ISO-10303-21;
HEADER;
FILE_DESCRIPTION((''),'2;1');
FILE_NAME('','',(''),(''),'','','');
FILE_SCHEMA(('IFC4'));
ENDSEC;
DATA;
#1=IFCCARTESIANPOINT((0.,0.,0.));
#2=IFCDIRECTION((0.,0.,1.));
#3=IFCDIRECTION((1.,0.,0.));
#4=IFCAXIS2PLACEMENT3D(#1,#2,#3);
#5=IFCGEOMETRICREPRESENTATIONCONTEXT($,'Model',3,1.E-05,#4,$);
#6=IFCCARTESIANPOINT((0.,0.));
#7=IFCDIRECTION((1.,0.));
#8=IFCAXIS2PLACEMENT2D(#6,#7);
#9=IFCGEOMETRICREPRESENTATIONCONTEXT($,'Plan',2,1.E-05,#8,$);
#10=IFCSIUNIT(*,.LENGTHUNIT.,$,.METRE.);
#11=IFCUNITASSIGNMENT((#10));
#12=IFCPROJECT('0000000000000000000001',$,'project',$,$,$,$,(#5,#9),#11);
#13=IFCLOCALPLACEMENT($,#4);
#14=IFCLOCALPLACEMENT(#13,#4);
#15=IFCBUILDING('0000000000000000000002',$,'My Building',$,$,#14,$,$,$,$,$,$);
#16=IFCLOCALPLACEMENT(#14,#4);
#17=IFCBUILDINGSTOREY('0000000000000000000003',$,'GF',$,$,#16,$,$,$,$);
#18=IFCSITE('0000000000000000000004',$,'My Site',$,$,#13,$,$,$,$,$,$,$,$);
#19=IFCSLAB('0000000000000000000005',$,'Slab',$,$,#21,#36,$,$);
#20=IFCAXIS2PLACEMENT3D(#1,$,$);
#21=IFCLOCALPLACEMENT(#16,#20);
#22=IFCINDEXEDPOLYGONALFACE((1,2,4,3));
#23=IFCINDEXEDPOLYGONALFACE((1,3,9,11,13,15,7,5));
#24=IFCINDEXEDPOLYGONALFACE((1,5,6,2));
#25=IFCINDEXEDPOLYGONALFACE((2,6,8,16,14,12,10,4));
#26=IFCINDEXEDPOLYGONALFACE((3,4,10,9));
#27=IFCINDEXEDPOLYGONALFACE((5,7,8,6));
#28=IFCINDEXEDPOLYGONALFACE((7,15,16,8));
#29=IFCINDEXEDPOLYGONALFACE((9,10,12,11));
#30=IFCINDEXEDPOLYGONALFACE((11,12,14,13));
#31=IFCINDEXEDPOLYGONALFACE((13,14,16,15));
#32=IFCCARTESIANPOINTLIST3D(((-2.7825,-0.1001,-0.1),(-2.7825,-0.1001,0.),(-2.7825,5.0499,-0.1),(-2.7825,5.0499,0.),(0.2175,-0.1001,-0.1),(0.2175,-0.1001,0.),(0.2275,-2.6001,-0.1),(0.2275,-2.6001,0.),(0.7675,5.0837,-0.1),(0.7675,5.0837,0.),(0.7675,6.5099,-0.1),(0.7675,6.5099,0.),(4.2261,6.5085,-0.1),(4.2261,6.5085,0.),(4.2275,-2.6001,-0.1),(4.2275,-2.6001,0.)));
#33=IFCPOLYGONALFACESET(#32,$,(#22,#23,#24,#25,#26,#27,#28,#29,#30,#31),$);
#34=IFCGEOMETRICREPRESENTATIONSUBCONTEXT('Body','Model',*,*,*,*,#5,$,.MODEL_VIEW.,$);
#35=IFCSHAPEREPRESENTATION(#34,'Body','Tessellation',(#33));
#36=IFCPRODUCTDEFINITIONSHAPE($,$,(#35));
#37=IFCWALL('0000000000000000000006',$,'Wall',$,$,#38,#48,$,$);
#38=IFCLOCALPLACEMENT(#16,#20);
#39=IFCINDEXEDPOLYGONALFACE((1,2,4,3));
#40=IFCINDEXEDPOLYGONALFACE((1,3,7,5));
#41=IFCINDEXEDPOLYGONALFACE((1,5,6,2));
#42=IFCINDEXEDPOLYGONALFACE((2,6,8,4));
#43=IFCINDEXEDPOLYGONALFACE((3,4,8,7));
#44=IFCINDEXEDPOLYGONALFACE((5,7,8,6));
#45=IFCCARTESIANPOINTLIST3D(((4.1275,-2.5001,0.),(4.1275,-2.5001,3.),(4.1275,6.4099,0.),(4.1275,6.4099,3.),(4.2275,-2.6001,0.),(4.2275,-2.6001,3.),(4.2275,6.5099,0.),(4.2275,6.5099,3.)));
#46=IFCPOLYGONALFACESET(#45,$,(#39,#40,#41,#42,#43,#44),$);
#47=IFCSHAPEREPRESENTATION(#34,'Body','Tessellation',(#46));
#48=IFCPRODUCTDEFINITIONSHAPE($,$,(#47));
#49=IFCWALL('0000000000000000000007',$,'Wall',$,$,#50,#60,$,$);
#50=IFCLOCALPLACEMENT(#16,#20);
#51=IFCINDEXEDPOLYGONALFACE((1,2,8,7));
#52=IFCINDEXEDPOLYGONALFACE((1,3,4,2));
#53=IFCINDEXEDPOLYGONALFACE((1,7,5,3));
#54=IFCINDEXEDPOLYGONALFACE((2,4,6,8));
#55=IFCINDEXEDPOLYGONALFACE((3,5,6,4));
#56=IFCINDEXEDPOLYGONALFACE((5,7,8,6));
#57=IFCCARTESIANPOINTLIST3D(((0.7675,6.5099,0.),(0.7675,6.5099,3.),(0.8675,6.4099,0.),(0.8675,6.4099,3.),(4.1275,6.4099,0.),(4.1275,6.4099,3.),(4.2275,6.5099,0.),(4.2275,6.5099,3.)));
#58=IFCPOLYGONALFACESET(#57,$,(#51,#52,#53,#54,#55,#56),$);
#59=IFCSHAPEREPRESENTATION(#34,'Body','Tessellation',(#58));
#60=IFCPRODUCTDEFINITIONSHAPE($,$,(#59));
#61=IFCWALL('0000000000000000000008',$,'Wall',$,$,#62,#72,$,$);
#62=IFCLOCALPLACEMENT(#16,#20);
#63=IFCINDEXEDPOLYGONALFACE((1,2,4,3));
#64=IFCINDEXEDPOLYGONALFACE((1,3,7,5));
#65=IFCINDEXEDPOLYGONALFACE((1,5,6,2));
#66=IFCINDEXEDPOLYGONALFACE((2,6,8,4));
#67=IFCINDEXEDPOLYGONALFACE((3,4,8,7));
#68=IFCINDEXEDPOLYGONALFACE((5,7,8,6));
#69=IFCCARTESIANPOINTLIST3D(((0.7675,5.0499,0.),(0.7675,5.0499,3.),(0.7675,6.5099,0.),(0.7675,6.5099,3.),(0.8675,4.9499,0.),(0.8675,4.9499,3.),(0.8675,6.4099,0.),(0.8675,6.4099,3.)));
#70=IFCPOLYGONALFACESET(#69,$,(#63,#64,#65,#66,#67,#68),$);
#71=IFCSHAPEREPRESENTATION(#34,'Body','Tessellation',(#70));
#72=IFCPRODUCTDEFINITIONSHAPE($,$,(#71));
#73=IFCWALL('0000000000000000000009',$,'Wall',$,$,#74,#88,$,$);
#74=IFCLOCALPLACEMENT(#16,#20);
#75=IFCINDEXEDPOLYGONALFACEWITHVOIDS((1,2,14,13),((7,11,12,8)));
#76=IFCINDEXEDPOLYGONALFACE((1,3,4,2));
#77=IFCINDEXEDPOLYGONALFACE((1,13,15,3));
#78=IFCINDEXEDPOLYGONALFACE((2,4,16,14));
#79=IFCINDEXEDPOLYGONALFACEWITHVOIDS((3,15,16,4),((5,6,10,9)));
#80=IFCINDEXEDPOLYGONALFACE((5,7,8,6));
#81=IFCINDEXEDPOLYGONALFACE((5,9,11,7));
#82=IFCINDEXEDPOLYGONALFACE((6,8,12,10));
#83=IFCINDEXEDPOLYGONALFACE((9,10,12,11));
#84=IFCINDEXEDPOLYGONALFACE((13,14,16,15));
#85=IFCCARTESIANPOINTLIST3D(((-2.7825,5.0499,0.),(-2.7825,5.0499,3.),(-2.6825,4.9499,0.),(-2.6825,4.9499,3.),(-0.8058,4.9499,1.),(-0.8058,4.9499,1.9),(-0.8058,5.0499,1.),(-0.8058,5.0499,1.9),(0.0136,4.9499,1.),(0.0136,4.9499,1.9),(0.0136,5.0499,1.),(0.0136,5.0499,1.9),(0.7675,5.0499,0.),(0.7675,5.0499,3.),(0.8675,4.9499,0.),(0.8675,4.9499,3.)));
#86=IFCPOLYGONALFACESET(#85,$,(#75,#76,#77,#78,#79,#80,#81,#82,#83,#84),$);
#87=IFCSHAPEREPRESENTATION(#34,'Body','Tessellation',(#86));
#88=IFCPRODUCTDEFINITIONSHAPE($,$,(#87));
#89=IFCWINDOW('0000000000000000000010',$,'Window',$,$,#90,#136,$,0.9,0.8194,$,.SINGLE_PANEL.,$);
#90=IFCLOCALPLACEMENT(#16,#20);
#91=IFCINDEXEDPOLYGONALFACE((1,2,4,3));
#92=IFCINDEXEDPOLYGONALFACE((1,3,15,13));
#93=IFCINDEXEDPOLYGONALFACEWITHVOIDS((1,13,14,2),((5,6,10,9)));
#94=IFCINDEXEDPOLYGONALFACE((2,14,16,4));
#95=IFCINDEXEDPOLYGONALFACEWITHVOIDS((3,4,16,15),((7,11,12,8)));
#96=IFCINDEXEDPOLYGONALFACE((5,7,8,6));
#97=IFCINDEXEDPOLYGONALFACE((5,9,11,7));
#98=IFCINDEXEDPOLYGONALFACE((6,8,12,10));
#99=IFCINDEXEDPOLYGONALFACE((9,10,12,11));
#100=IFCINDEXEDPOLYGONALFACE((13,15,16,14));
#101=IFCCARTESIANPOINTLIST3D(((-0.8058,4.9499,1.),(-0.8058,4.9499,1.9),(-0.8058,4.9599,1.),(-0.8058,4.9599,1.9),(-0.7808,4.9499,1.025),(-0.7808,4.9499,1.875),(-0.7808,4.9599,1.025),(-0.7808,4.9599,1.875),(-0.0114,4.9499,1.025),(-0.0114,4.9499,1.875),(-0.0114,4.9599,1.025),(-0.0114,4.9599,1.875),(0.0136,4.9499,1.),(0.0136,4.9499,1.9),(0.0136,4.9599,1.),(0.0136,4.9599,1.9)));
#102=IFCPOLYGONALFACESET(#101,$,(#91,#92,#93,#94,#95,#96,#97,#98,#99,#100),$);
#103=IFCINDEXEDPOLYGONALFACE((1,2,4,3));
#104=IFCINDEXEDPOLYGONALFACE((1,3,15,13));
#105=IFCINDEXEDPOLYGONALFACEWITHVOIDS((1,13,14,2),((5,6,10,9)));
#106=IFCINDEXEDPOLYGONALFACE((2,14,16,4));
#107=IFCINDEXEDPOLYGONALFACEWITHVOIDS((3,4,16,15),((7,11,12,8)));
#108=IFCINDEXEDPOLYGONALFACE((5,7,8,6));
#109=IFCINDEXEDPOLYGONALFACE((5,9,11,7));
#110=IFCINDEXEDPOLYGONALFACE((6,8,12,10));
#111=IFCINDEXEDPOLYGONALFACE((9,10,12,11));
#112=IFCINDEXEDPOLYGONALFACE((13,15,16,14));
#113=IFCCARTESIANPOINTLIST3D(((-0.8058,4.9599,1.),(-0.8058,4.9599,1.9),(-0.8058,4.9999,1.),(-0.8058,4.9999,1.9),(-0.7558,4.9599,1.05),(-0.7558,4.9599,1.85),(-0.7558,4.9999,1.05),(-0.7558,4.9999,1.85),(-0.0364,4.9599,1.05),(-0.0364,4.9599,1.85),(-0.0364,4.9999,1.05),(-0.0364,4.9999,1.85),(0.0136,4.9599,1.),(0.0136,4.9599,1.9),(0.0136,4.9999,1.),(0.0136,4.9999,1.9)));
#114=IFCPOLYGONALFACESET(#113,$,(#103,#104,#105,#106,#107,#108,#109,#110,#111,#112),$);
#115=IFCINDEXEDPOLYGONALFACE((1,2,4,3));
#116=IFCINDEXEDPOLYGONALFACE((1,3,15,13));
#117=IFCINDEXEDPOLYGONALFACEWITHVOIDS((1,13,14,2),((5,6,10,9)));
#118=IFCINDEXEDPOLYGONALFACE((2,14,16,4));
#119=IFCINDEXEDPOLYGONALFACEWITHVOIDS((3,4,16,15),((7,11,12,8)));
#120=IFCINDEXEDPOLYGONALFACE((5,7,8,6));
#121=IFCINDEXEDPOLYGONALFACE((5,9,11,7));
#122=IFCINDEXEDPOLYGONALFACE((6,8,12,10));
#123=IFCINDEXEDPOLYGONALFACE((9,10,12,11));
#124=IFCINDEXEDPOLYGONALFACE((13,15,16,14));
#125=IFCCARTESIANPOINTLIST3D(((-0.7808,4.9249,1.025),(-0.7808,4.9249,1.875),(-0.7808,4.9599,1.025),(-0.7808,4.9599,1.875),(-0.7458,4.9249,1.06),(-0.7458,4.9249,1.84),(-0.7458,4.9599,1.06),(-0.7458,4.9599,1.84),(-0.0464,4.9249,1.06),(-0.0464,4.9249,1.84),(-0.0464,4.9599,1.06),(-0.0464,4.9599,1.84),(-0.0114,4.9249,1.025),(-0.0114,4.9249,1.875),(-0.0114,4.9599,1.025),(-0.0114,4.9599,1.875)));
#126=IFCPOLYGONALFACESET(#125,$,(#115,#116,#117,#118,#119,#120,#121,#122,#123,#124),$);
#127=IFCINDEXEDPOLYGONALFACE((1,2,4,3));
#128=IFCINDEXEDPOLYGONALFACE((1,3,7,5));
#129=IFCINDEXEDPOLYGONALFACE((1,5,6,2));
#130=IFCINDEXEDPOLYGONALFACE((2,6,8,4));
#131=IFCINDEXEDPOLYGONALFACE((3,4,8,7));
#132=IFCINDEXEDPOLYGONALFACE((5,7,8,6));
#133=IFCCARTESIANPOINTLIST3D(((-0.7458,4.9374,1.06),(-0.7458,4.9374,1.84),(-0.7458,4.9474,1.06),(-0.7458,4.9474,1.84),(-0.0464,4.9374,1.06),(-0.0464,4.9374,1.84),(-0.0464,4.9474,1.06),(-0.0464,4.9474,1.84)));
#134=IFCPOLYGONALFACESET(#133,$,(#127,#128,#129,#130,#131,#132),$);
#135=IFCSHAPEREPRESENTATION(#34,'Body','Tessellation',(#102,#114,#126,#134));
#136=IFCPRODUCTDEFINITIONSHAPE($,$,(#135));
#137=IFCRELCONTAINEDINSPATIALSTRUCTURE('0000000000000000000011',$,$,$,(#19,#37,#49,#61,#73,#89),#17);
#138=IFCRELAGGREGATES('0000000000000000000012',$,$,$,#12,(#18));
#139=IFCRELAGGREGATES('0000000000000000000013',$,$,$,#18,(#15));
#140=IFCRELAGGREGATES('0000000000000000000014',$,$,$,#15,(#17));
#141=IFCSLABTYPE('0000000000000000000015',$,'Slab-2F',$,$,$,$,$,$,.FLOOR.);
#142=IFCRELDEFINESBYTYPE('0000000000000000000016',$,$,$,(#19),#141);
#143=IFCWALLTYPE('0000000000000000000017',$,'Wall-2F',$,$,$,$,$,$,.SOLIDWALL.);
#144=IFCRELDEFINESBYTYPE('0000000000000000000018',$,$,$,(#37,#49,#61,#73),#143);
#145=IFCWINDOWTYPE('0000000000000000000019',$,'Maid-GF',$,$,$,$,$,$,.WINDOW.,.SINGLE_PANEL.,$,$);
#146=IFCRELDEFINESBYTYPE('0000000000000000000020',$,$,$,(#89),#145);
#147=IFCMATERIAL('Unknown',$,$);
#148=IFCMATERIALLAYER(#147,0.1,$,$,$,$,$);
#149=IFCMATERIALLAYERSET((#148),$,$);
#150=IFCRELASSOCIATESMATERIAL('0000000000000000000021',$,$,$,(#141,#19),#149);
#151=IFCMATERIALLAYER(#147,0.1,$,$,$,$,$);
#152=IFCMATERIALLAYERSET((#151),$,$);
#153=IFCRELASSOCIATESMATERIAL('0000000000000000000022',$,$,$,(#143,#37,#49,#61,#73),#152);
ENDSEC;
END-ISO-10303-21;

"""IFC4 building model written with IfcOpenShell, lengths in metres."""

from ifc_helpers import new_model, entity, si_unit, frame, origin_with_axes, origin_2d_with_axis, place, context, subcontext, project, spatial, line, indexed_curve, outline, extrude, shape, source, transform, mapped, material, layer, layer_set, layer_usage, type_object, type_shapes, element, fill, save


model = new_model("IFC4")

# Units and contexts
model_context = context("Model", 3, precision=1e-05, world=origin_with_axes())
plan_context = context("Plan", 2, precision=1e-05, world=origin_2d_with_axis())
body_context_1 = subcontext(model_context, "Body", "Model", "MODEL_VIEW")
body_context_2 = subcontext(plan_context, "Body", "Plan", "PLAN_VIEW")
ifc_project = project(units=[si_unit("LENGTHUNIT", "METRE")], contexts=[model_context, plan_context])

# Site, building, storey
site_placement = place(None, origin_with_axes())
site = spatial("IfcSite", under=ifc_project, at=site_placement, Name="My Site")
building_placement = place(site_placement, origin_with_axes())
building = spatial("IfcBuilding", under=site, at=building_placement, Name="My Building")
storey_placement = place(building_placement, origin_with_axes())
storey = spatial("IfcBuildingStorey", under=building, at=storey_placement, Name="GF")

# Slab
ifc_material = material(Name="Unknown")
ifc_layer_1 = layer(ifc_material, 0.1)
ifc_layer_set_1 = layer_set([ifc_layer_1])
ifc_layer_usage_1 = layer_usage(ifc_layer_set_1, "AXIS3", "POSITIVE", -0.1)
slab_type = type_object("IfcSlabType", Name="Slab-2F", PredefinedType="FLOOR", material=ifc_layer_set_1)
slab_placement = place(storey_placement, frame((4.2275, -2.6001, 0.0), z_axis=(0.0, 0.0, 1.0), x_axis=(1.0, 0.0, 0.0)))
element("IfcSlab", 1, at=slab_placement, inside=storey, type_object=slab_type, material=ifc_layer_usage_1, Name="Slab", context=body_context_1, shape_type="SweptSolid", body=[
    extrude(outline(indexed_curve([(0.0, 0.0), (-0.0014, 9.1086), (-3.46, 9.11), (-3.46, 7.6838), (-7.01, 7.65), (-7.01, 2.5), (-4.01, 2.5), (-4.0, 0.0), (0.0, 0.0)])), frame((0.0, 0.0, -0.1), z_axis=(0.0, 0.0, 1.0), x_axis=(1.0, 0.0, 0.0)), (0.0, 0.0, 1.0), 0.1),
])

# Shared definitions
ifc_layer_2 = layer(ifc_material, 0.1)
ifc_layer_set_2 = layer_set([ifc_layer_2])
wall_type = type_object("IfcWallType", Name="Wall-2F", PredefinedType="SOLIDWALL", material=ifc_layer_set_2)

# Walls
ifc_layer_usage_2 = layer_usage(ifc_layer_set_2, "AXIS2", "POSITIVE", 0.0)
wall_1_placement = place(storey_placement, frame((4.2275, -2.6001, 0.0), z_axis=(0.0, 0.0, 1.0), x_axis=(0.0, 1.0, 0.0)))
element("IfcWall", 2, at=wall_1_placement, inside=storey, type_object=wall_type, material=ifc_layer_usage_2, Name="Wall", context=body_context_1, shape_type="SweptSolid", body=[
    extrude(outline(indexed_curve([(0.0, 0.0), (0.1, 0.1), (9.01, 0.1), (9.11, 0.0)], segments=[line(1, 2, 3, 4, 1)])), origin_with_axes(), (0.0, 0.0, 1.0), 3.0),
])
ifc_layer_usage_3 = layer_usage(ifc_layer_set_2, "AXIS2", "POSITIVE", 0.0)
wall_2_placement = place(storey_placement, frame((4.2275, 6.5099, 0.0), z_axis=(0.0, 0.0, 1.0), x_axis=(-1.0, 0.0, 0.0)))
element("IfcWall", 3, at=wall_2_placement, inside=storey, type_object=wall_type, material=ifc_layer_usage_3, Name="Wall", context=body_context_1, shape_type="SweptSolid", body=[
    extrude(outline(indexed_curve([(0.0, 0.0), (0.1, 0.1), (3.36, 0.1), (3.46, 0.0)], segments=[line(1, 2, 3, 4, 1)])), origin_with_axes(), (0.0, 0.0, 1.0), 3.0),
])
ifc_layer_usage_4 = layer_usage(ifc_layer_set_2, "AXIS2", "POSITIVE", 0.0)
wall_3_placement = place(storey_placement, frame((0.7675, 6.5099, 0.0), z_axis=(0.0, 0.0, 1.0), x_axis=(0.0, -1.0, 0.0)))
element("IfcWall", 4, at=wall_3_placement, inside=storey, type_object=wall_type, material=ifc_layer_usage_4, Name="Wall", context=body_context_1, shape_type="SweptSolid", body=[
    extrude(outline(indexed_curve([(0.0, 0.0), (0.1, 0.1), (1.56, 0.1), (1.46, 0.0)], segments=[line(1, 2, 3, 4, 1)])), origin_with_axes(), (0.0, 0.0, 1.0), 3.0),
])

# Wall, opening, window
ifc_layer_usage_5 = layer_usage(ifc_layer_set_2, "AXIS2", "POSITIVE", 0.0)
wall_4_placement = place(storey_placement, frame((0.7675, 5.0499, 0.0), z_axis=(0.0, 0.0, 1.0), x_axis=(-1.0, 0.0, 0.0)))
wall_4 = element("IfcWall", 5, at=wall_4_placement, inside=storey, type_object=wall_type, material=ifc_layer_usage_5, Name="Wall", context=body_context_1, shape_type="SweptSolid", body=[
    extrude(outline(indexed_curve([(0.0, 0.0), (-0.1, 0.1), (3.45, 0.1), (3.55, 0.0)], segments=[line(1, 2, 3, 4, 1)])), origin_with_axes(), (0.0, 0.0, 1.0), 3.0),
])
shared_shape_1 = source(origin_with_axes(), body_context_1, "Body", "SweptSolid", [
    extrude(outline(indexed_curve([(0.0, 0.0), (0.8194, 0.0), (0.8194, 0.9), (0.0, 0.9)], segments=[line(1, 2, 3, 4, 1)])), frame((0.0, -0.6, 0.0), z_axis=(0.0, -1.0, 0.0), x_axis=(1.0, 0.0, 0.0)), (0.0, 0.0, -1.0), 1.2),
])
opening_1_placement = place(wall_4_placement, frame((0.7539, 0.0, 1.0), z_axis=(0.0, 0.0, 1.0), x_axis=(1.0, 0.0, 0.0)))
opening_1 = element("IfcOpeningElement", 6, at=opening_1_placement, cuts=wall_4, PredefinedType="OPENING", context=body_context_1, shape_type="MappedRepresentation", body=[
    mapped(shared_shape_1, transform((0.0, 0.0, 0.0), x_axis=(1.0, 0.0, 0.0), y_axis=(0.0, 1.0, 0.0), z_axis=(0.0, 0.0, 1.0), scale=1.0)),
])
window_type_1 = type_object("IfcWindowType", Name="Maid-GF", PartitioningType="SINGLE_PANEL", PredefinedType="WINDOW")
shared_shape_2 = source(origin_with_axes(), body_context_1, "Body", "SweptSolid", [
    extrude(outline(indexed_curve([(0.0, 0.0), (0.8194, 0.0), (0.8194, 0.9), (0.0, 0.9)], segments=[line(1, 2, 3, 4, 1)]), holes=[indexed_curve([(0.025, 0.025), (0.7944, 0.025), (0.7944, 0.875), (0.025, 0.875)], segments=[line(1, 2, 3, 4, 1)])]), frame((0.0, 0.09, 0.0), z_axis=(0.0, -1.0, 0.0), x_axis=(1.0, 0.0, 0.0)), (0.0, 0.0, -1.0), 0.01),
    extrude(outline(indexed_curve([(0.0, 0.0), (0.8194, 0.0), (0.8194, 0.9), (0.0, 0.9)], segments=[line(1, 2, 3, 4, 1)]), holes=[indexed_curve([(0.05, 0.05), (0.7694, 0.05), (0.7694, 0.85), (0.05, 0.85)], segments=[line(1, 2, 3, 4, 1)])]), frame((0.0, 0.05, 0.0), z_axis=(0.0, -1.0, 0.0), x_axis=(1.0, 0.0, 0.0)), (0.0, 0.0, -1.0), 0.04),
    extrude(outline(indexed_curve([(0.0, 0.0), (0.7694, 0.0), (0.7694, 0.85), (0.0, 0.85)], segments=[line(1, 2, 3, 4, 1)]), holes=[indexed_curve([(0.035, 0.035), (0.7344, 0.035), (0.7344, 0.815), (0.035, 0.815)], segments=[line(1, 2, 3, 4, 1)])]), frame((0.025, 0.09, 0.025), z_axis=(0.0, -1.0, 0.0), x_axis=(1.0, 0.0, 0.0)), (0.0, 0.0, -1.0), 0.035),
    extrude(outline(indexed_curve([(0.035, 0.035), (0.7344, 0.035), (0.7344, 0.815), (0.035, 0.815)], segments=[line(1, 2, 3, 4, 1)])), frame((0.025, 0.1025, 0.025), z_axis=(0.0, -1.0, 0.0), x_axis=(1.0, 0.0, 0.0)), (0.0, 0.0, -1.0), 0.01),
])
shared_shape_3 = source(origin_with_axes(), body_context_2, "Body", "Curve2D", [
    entity("IfcIndexedPolyCurve", entity("IfcCartesianPointList2D", [[0.05, 0.05], [0.7694, 0.05]])),
    entity("IfcIndexedPolyCurve", entity("IfcCartesianPointList2D", [[0.0, 0.1], [0.025, 0.1], [0.025, 0.09], [0.05, 0.09], [0.05, 0.05], [0.0, 0.05]]), [entity("IfcLineIndex", [1, 2, 3, 4, 5, 6, 1])]),
    entity("IfcIndexedPolyCurve", entity("IfcCartesianPointList2D", [[0.8194, 0.1], [0.7944, 0.1], [0.7944, 0.09], [0.7694, 0.09], [0.7694, 0.05], [0.8194, 0.05]]), [entity("IfcLineIndex", [1, 2, 3, 4, 5, 6, 1])]),
    entity("IfcIndexedPolyCurve", entity("IfcCartesianPointList2D", [[0.025, 0.09], [0.06, 0.09], [0.06, 0.125], [0.025, 0.125]]), [entity("IfcLineIndex", [1, 2, 3, 4, 1])]),
    entity("IfcIndexedPolyCurve", entity("IfcCartesianPointList2D", [[0.7944, 0.09], [0.7594, 0.09], [0.7594, 0.125], [0.7944, 0.125]]), [entity("IfcLineIndex", [1, 2, 3, 4, 1])]),
    entity("IfcIndexedPolyCurve", entity("IfcCartesianPointList2D", [[0.06, 0.09], [0.7594, 0.09]])),
    entity("IfcIndexedPolyCurve", entity("IfcCartesianPointList2D", [[0.06, 0.125], [0.7594, 0.125]])),
    entity("IfcIndexedPolyCurve", entity("IfcCartesianPointList2D", [[0.06, 0.1075], [0.7594, 0.1075]])),
])
type_shapes(window_type_1, [shared_shape_2, shared_shape_3])
window_1_placement = place(opening_1_placement, frame((0.0, 0.0, 0.0), z_axis=(0.0, 0.0, 1.0), x_axis=(1.0, 0.0, 0.0)))
window_1 = element("IfcWindow", 7, at=window_1_placement, inside=storey, type_object=window_type_1, Name="Window", OverallHeight=0.9, OverallWidth=0.8194, PartitioningType="SINGLE_PANEL", shapes=[
    shape(body_context_1, "Body", "MappedRepresentation", [mapped(shared_shape_2, transform((0.0, 0.0, 0.0), x_axis=(1.0, 0.0, 0.0), y_axis=(0.0, 1.0, 0.0), z_axis=(0.0, 0.0, 1.0), scale=1.0))]),
    shape(body_context_2, "Body", "MappedRepresentation", [mapped(shared_shape_3, transform((0.0, 0.0, 0.0), x_axis=(1.0, 0.0, 0.0), y_axis=(0.0, 1.0, 0.0), z_axis=(0.0, 0.0, 1.0), scale=1.0))]),
])
fill(opening_1, window_1)

save(model, "model.ifc")
